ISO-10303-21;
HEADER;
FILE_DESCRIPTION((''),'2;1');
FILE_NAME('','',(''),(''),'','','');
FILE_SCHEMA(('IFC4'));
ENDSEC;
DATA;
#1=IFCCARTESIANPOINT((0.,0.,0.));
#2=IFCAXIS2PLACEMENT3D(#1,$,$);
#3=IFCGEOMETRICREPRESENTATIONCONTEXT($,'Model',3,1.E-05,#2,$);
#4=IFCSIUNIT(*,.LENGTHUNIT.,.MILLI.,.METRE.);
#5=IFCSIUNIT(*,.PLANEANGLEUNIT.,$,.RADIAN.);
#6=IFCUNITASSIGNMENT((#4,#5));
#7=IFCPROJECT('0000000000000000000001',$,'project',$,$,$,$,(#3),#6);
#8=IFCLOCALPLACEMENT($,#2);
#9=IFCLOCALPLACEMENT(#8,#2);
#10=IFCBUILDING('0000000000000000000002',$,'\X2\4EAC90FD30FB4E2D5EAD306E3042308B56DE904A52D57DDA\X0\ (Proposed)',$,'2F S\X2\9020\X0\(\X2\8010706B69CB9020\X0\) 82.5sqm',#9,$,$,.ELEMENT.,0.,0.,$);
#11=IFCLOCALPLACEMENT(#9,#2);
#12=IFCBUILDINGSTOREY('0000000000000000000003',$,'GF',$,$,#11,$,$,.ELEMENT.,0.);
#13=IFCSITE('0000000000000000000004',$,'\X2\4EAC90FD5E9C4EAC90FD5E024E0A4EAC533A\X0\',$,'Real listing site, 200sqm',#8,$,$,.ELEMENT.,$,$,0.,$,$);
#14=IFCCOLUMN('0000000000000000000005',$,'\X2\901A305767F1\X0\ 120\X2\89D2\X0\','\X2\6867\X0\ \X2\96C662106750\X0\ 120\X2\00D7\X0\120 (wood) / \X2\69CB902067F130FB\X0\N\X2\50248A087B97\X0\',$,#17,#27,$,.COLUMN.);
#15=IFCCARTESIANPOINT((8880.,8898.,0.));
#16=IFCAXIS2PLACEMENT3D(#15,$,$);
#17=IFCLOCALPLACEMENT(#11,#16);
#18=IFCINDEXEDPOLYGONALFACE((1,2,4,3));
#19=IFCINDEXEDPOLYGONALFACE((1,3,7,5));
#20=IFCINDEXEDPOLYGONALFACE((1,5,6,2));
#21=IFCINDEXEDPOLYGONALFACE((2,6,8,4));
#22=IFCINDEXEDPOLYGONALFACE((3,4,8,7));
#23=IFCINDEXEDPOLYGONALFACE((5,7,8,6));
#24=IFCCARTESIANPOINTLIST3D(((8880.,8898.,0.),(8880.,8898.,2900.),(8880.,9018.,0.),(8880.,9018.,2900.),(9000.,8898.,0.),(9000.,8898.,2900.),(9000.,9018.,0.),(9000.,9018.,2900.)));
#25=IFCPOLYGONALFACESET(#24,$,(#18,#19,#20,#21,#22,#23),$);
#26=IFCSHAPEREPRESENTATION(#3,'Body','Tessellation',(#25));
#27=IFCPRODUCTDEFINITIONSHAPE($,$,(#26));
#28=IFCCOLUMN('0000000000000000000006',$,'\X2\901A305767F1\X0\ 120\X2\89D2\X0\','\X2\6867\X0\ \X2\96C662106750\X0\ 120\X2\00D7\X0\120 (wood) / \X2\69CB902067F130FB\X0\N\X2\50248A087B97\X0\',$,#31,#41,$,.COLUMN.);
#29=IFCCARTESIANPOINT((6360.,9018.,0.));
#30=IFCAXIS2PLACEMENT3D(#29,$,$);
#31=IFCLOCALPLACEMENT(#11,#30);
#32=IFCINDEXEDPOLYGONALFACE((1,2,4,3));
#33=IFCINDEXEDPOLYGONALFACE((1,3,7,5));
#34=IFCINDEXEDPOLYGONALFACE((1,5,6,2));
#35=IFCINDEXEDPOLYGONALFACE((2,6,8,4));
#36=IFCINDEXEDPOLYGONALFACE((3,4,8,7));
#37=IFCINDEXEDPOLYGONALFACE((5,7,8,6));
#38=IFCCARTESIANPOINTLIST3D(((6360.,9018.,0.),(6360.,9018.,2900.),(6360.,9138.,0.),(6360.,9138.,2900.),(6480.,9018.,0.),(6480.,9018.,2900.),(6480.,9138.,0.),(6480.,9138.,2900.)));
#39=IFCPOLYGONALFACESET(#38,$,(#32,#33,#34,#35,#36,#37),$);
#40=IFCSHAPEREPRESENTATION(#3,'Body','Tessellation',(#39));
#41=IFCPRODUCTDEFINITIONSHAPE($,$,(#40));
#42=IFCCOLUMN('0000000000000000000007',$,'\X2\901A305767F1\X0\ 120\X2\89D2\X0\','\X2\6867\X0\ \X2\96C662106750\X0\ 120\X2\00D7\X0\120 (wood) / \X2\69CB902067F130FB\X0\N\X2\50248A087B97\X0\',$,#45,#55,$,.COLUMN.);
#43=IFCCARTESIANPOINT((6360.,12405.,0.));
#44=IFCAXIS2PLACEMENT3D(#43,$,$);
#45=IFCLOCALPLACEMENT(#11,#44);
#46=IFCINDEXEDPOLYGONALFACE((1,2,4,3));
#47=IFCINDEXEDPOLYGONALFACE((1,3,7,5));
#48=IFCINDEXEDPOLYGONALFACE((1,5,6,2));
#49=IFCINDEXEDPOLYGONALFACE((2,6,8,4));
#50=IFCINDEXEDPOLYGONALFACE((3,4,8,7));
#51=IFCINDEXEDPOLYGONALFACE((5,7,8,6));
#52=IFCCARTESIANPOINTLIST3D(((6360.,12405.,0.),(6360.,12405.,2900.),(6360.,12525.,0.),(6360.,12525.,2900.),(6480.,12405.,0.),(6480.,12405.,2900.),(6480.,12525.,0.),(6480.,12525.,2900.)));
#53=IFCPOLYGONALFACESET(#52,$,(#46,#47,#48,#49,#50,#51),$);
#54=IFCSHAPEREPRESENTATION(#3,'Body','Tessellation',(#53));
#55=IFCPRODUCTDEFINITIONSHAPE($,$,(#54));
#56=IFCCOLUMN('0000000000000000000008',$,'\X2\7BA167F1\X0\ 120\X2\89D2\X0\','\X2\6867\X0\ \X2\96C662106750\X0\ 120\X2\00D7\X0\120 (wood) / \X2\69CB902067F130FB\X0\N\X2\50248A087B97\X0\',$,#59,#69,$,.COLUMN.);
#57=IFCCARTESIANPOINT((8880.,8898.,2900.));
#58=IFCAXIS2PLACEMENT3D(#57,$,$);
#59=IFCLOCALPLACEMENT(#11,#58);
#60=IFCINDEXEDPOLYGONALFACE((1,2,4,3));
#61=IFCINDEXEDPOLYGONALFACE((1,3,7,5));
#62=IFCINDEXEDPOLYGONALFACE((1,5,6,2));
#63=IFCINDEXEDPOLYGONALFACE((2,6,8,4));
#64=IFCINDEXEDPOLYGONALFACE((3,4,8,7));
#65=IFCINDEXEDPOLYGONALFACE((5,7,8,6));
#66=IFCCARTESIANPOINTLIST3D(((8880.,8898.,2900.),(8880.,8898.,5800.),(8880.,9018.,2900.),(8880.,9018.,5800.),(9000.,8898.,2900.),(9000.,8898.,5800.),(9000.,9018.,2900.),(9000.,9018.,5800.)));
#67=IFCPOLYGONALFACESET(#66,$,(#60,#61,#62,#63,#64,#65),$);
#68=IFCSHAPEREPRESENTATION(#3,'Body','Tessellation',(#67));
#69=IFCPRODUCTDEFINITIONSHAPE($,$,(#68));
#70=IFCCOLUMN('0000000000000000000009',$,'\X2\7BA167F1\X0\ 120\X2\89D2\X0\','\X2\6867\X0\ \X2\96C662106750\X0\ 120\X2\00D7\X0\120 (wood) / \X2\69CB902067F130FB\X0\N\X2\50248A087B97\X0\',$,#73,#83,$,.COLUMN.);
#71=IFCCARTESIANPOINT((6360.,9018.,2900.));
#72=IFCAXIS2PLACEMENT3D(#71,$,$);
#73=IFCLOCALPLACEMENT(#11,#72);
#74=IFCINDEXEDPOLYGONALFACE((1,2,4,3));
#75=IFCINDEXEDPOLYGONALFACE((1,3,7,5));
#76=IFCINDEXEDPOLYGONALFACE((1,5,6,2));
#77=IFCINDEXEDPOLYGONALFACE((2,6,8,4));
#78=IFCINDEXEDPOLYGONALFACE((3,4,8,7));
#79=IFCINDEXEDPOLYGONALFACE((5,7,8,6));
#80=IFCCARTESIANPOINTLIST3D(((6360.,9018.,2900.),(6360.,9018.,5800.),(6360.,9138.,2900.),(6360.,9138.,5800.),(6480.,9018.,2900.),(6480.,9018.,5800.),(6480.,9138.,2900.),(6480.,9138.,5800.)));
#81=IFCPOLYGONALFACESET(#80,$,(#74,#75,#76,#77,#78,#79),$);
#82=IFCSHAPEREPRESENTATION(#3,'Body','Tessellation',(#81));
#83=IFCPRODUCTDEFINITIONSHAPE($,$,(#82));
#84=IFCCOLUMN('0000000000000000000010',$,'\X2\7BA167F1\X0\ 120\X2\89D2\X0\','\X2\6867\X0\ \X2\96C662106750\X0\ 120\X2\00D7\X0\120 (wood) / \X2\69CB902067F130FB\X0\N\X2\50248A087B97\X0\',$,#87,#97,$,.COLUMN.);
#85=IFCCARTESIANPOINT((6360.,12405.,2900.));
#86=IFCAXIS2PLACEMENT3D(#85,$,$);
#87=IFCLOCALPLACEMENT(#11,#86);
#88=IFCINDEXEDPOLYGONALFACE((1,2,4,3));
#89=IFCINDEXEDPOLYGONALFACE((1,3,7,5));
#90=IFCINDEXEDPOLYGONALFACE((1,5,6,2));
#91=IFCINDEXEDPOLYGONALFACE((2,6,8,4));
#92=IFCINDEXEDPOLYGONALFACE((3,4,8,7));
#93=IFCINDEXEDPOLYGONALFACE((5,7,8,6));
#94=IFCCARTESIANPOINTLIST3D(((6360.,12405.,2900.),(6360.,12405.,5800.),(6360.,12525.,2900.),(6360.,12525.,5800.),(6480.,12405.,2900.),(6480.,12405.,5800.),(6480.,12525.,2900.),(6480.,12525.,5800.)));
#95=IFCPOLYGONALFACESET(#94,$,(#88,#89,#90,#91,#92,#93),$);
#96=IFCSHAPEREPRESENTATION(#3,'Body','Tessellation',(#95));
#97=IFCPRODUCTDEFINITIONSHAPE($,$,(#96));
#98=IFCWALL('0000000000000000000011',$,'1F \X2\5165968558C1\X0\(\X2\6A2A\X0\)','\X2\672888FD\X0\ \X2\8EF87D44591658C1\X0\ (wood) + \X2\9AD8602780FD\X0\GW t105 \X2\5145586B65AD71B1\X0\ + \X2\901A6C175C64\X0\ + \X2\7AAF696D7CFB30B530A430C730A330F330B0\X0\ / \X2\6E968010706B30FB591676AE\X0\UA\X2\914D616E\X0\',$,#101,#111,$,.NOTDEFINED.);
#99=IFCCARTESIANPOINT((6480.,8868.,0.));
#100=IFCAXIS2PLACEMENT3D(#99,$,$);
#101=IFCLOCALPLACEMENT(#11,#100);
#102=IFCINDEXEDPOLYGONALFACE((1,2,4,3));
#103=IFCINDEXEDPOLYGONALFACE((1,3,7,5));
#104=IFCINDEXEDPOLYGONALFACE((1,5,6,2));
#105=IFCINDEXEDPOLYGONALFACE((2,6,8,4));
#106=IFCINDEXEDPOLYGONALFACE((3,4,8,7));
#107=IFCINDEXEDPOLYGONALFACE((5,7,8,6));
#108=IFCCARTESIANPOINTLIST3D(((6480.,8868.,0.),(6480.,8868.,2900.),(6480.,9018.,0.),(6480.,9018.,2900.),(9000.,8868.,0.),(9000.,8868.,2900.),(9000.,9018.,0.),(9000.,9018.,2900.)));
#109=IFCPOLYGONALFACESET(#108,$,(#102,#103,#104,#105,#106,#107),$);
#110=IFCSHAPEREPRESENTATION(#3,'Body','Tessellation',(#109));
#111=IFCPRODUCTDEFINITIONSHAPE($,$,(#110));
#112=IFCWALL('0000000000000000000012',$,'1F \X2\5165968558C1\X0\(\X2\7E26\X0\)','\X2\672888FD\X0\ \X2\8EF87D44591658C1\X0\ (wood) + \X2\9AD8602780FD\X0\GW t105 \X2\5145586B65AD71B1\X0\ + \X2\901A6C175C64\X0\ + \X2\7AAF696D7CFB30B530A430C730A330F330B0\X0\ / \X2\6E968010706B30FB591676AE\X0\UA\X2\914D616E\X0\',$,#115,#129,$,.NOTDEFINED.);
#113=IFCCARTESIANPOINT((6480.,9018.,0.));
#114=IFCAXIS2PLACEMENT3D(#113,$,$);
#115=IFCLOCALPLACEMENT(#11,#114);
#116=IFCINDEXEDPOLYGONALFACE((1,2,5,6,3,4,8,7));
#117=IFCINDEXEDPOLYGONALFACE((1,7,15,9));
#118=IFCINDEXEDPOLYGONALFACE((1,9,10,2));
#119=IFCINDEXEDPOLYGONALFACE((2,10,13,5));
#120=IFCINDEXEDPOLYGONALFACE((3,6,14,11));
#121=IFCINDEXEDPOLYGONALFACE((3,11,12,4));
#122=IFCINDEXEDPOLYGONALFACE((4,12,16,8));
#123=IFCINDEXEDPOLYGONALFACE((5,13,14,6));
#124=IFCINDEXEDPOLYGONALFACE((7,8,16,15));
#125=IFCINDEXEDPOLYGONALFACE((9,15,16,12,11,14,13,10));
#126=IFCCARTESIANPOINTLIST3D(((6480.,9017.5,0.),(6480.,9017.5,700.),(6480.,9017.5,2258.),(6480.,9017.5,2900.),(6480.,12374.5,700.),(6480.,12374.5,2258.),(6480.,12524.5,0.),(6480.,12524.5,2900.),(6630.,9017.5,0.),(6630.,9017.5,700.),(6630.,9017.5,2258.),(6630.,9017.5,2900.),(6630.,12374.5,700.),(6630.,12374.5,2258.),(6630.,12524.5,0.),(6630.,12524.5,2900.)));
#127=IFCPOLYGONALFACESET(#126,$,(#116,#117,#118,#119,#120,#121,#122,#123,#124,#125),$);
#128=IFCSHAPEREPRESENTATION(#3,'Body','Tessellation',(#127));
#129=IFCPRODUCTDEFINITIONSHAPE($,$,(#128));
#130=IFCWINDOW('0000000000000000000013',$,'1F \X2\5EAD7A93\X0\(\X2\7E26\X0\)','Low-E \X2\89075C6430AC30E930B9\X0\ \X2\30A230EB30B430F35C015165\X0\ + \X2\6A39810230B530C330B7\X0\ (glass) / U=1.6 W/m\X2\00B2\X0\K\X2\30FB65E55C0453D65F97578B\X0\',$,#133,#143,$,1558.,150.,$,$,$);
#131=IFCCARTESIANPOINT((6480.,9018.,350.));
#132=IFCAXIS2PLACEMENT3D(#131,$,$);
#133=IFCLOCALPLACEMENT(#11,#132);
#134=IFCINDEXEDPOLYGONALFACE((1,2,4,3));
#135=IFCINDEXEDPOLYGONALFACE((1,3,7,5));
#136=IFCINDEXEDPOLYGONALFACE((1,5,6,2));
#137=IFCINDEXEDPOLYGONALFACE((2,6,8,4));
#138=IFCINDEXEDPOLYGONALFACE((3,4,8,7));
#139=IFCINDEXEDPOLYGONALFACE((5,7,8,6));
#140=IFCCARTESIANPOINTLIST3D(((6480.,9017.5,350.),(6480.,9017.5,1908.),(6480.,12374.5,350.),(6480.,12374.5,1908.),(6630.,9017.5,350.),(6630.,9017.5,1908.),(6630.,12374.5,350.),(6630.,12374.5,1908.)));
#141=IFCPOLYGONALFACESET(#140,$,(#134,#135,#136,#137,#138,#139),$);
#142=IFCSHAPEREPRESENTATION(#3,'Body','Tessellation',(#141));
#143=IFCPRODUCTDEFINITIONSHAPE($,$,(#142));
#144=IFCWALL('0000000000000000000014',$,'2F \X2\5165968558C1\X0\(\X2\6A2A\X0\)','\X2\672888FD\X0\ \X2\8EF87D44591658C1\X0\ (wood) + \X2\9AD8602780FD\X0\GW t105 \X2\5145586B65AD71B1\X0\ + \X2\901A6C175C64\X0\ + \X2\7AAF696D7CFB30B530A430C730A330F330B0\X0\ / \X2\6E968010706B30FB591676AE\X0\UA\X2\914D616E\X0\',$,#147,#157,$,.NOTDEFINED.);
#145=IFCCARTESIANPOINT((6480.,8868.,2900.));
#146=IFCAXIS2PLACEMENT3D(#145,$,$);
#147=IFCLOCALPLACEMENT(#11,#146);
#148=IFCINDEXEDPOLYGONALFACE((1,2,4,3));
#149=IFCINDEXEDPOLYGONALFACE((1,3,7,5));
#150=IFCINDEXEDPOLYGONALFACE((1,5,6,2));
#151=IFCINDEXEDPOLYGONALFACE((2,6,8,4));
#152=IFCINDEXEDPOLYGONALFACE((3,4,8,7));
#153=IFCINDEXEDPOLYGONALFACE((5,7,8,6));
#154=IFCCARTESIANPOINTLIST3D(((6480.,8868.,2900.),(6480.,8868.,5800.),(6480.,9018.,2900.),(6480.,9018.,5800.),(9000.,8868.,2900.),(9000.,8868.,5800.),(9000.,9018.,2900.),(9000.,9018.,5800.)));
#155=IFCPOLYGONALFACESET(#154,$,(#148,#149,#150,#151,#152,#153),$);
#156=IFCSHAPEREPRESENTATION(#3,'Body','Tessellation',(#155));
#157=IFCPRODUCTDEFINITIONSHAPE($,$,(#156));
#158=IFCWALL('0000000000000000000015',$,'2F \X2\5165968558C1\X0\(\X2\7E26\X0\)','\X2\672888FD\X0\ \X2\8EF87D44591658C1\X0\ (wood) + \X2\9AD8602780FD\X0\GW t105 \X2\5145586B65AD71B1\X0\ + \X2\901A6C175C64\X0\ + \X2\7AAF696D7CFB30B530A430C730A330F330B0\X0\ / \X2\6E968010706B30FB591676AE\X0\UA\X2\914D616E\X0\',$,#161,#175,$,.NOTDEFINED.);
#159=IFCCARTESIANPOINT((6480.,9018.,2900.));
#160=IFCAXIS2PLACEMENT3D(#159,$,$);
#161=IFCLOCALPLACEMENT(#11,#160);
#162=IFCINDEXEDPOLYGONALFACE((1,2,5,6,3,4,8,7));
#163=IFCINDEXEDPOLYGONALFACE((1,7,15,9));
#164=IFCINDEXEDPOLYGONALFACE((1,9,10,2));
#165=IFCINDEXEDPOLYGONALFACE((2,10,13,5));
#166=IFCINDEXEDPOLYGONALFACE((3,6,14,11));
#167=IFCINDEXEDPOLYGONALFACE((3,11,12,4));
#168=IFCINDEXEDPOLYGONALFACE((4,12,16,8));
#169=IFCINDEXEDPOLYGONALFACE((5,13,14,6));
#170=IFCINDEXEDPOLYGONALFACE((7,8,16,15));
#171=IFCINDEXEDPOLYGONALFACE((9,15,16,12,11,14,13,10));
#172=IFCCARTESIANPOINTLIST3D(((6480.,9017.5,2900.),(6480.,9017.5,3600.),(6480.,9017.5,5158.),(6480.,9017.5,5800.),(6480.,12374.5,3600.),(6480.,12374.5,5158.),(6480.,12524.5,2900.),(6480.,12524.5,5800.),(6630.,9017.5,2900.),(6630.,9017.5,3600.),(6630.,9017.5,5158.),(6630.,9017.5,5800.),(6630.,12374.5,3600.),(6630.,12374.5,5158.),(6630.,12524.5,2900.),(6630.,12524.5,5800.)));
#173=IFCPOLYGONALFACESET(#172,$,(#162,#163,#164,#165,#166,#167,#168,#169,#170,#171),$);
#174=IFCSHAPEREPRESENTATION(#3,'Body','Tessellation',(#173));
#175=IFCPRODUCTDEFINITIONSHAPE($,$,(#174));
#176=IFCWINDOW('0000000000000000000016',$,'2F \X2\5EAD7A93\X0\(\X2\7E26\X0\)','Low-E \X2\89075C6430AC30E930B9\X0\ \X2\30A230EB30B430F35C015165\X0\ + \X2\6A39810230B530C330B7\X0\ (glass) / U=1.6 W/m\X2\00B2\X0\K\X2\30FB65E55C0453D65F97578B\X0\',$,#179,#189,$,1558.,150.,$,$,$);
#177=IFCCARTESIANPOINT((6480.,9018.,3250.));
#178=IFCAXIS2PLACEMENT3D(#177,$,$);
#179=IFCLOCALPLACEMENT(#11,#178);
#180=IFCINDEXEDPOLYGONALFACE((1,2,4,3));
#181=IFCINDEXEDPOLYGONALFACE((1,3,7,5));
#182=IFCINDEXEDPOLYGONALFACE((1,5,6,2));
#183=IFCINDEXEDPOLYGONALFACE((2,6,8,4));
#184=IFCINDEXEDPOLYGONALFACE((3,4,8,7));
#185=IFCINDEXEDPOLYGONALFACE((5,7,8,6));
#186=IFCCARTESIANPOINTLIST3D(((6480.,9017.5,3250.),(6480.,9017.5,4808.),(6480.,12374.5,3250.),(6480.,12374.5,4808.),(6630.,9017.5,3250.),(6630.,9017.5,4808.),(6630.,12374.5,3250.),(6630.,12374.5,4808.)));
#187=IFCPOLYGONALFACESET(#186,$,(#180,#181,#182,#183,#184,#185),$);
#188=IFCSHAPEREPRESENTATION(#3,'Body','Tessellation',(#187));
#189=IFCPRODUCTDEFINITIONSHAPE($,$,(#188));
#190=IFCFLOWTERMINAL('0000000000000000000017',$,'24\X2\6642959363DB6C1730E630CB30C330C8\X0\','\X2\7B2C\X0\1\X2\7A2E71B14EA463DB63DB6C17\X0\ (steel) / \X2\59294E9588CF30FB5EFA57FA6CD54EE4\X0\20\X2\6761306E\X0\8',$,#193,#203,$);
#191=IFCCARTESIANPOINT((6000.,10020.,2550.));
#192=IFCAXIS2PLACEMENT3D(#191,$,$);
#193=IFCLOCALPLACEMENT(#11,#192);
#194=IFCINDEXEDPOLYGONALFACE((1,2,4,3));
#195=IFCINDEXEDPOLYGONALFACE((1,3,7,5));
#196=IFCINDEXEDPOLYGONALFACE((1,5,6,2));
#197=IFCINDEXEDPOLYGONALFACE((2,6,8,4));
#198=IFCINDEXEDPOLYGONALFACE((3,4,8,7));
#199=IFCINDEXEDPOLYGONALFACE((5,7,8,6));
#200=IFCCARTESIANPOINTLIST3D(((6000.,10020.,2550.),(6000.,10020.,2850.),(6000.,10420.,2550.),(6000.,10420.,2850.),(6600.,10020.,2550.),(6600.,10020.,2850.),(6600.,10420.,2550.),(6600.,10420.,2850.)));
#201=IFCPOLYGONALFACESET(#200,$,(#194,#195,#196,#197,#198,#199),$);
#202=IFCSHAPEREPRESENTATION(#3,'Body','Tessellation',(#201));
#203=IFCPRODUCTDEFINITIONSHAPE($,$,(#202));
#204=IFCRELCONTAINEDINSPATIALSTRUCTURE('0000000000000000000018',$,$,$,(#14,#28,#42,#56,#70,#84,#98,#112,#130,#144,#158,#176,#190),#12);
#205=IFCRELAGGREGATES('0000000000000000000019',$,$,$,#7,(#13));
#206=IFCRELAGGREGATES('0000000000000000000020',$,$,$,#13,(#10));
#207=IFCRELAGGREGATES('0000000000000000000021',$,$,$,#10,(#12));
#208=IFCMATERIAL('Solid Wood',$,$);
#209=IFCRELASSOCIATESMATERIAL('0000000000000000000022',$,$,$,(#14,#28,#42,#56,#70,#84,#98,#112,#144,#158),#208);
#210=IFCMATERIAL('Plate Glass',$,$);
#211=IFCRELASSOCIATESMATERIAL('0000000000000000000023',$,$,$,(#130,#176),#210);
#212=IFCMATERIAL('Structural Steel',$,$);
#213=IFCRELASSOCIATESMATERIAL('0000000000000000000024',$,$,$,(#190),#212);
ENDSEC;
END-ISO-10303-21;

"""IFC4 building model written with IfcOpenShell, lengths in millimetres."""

from ifc_helpers import new_model, si_unit, frame, frame_2d, origin, place, context, project, spatial, rectangle, extrude, material, element, fill, save


model = new_model("IFC4")

# Units and contexts
model_context = context("Model", 3, precision=1e-05, world=origin())
ifc_project = project(units=[si_unit("LENGTHUNIT", "METRE", prefix="MILLI"), si_unit("PLANEANGLEUNIT", "RADIAN")], contexts=[model_context])

# Site, building, storey
site_placement = place(None, origin())
site = spatial("IfcSite", under=ifc_project, at=site_placement, Name="京都府京都市上京区", ObjectType="Real listing site, 200sqm", CompositionType="ELEMENT", RefElevation=0.0)
building_placement = place(site_placement, origin())
building = spatial("IfcBuilding", under=site, at=building_placement, Name="京都・中庭のある回遊動線 (Proposed)", ObjectType="2F S造(耐火構造) 82.5sqm", CompositionType="ELEMENT", ElevationOfRefHeight=0.0, ElevationOfTerrain=0.0)
storey_placement = place(building_placement, origin())
storey = spatial("IfcBuildingStorey", under=building, at=storey_placement, Name="GF", CompositionType="ELEMENT", Elevation=0.0)

# Columns
ifc_material_1 = material(Name="Solid Wood")
column_1_placement = place(storey_placement, frame((8880.0, 8898.0, 0.0)))
element("IfcColumn", 1, at=column_1_placement, inside=storey, material=ifc_material_1, Name="通し柱 120角", Description="桧 集成材 120×120 (wood) / 構造柱・N値計算", PredefinedType="COLUMN", context=model_context, shape_type="SweptSolid", body=[
    extrude(rectangle(XDim=120.0, YDim=120.0, at=frame_2d((60.0, 60.0))), frame((8880.0, 8898.0, 0.0)), (0.0, 0.0, 1.0), 2900.0),
])
column_2_placement = place(storey_placement, frame((6360.0, 9018.0, 0.0)))
element("IfcColumn", 2, at=column_2_placement, inside=storey, material=ifc_material_1, Name="通し柱 120角", Description="桧 集成材 120×120 (wood) / 構造柱・N値計算", PredefinedType="COLUMN", context=model_context, shape_type="SweptSolid", body=[
    extrude(rectangle(XDim=120.0, YDim=120.0, at=frame_2d((60.0, 60.0))), frame((6360.0, 9018.0, 0.0)), (0.0, 0.0, 1.0), 2900.0),
])
column_3_placement = place(storey_placement, frame((6360.0, 12405.0, 0.0)))
element("IfcColumn", 3, at=column_3_placement, inside=storey, material=ifc_material_1, Name="通し柱 120角", Description="桧 集成材 120×120 (wood) / 構造柱・N値計算", PredefinedType="COLUMN", context=model_context, shape_type="SweptSolid", body=[
    extrude(rectangle(XDim=120.0, YDim=120.0, at=frame_2d((60.0, 60.0))), frame((6360.0, 12405.0, 0.0)), (0.0, 0.0, 1.0), 2900.0),
])
column_4_placement = place(storey_placement, frame((8880.0, 8898.0, 2900.0)))
element("IfcColumn", 4, at=column_4_placement, inside=storey, material=ifc_material_1, Name="管柱 120角", Description="桧 集成材 120×120 (wood) / 構造柱・N値計算", PredefinedType="COLUMN", context=model_context, shape_type="SweptSolid", body=[
    extrude(rectangle(XDim=120.0, YDim=120.0, at=frame_2d((60.0, 60.0))), frame((8880.0, 8898.0, 2900.0)), (0.0, 0.0, 1.0), 2900.0),
])
column_5_placement = place(storey_placement, frame((6360.0, 9018.0, 2900.0)))
element("IfcColumn", 5, at=column_5_placement, inside=storey, material=ifc_material_1, Name="管柱 120角", Description="桧 集成材 120×120 (wood) / 構造柱・N値計算", PredefinedType="COLUMN", context=model_context, shape_type="SweptSolid", body=[
    extrude(rectangle(XDim=120.0, YDim=120.0, at=frame_2d((60.0, 60.0))), frame((6360.0, 9018.0, 2900.0)), (0.0, 0.0, 1.0), 2900.0),
])
column_6_placement = place(storey_placement, frame((6360.0, 12405.0, 2900.0)))
element("IfcColumn", 6, at=column_6_placement, inside=storey, material=ifc_material_1, Name="管柱 120角", Description="桧 集成材 120×120 (wood) / 構造柱・N値計算", PredefinedType="COLUMN", context=model_context, shape_type="SweptSolid", body=[
    extrude(rectangle(XDim=120.0, YDim=120.0, at=frame_2d((60.0, 60.0))), frame((6360.0, 12405.0, 2900.0)), (0.0, 0.0, 1.0), 2900.0),
])

# Wall
wall_1_placement = place(storey_placement, frame((6480.0, 8868.0, 0.0)))
element("IfcWall", 7, at=wall_1_placement, inside=storey, material=ifc_material_1, Name="1F 入隅壁(横)", Description="木製 軸組外壁 (wood) + 高性能GW t105 充填断熱 + 通気層 + 窯業系サイディング / 準耐火・外皮UA配慮", PredefinedType="NOTDEFINED", context=model_context, shape_type="SweptSolid", body=[
    extrude(rectangle(XDim=2520.0, YDim=150.0, at=frame_2d((1260.0, 75.0))), frame((6480.0, 8868.0, 0.0)), (0.0, 0.0, 1.0), 2900.0),
])

# Wall, opening, window
wall_2_placement = place(storey_placement, frame((6480.0, 9018.0, 0.0)))
wall_2 = element("IfcWall", 8, at=wall_2_placement, inside=storey, material=ifc_material_1, Name="1F 入隅壁(縦)", Description="木製 軸組外壁 (wood) + 高性能GW t105 充填断熱 + 通気層 + 窯業系サイディング / 準耐火・外皮UA配慮", PredefinedType="NOTDEFINED", context=model_context, shape_type="SweptSolid", body=[
    extrude(rectangle(XDim=150.0, YDim=3507.0, at=frame_2d((75.0, 1753.0))), frame((6480.0, 9018.0, 0.0)), (0.0, 0.0, 1.0), 2900.0),
])
opening_1_placement = place(storey_placement, frame((6480.0, 9018.0, 350.0)))
opening_1 = element("IfcOpeningElement", 9, at=opening_1_placement, cuts=wall_2, PredefinedType="NOTDEFINED", context=model_context, shape_type="SweptSolid", body=[
    extrude(rectangle(XDim=150.0, YDim=3357.0, at=frame_2d((75.0, 1678.0))), frame((6480.0, 9018.0, 350.0)), (0.0, 0.0, 1.0), 1558.0),
])
ifc_material_2 = material(Name="Plate Glass")
window_1_placement = place(storey_placement, frame((6480.0, 9018.0, 350.0)))
window_1 = element("IfcWindow", 10, at=window_1_placement, inside=storey, material=ifc_material_2, Name="1F 庭窓(縦)", Description="Low-E 複層ガラス アルゴン封入 + 樹脂サッシ (glass) / U=1.6 W/m²K・日射取得型", OverallHeight=1558.0, OverallWidth=150.0, context=model_context, shape_type="SweptSolid", body=[
    extrude(rectangle(XDim=150.0, YDim=3357.0, at=frame_2d((75.0, 1678.0))), frame((6480.0, 9018.0, 350.0)), (0.0, 0.0, 1.0), 1558.0),
])
fill(opening_1, window_1)

# Wall
wall_3_placement = place(storey_placement, frame((6480.0, 8868.0, 2900.0)))
element("IfcWall", 11, at=wall_3_placement, inside=storey, material=ifc_material_1, Name="2F 入隅壁(横)", Description="木製 軸組外壁 (wood) + 高性能GW t105 充填断熱 + 通気層 + 窯業系サイディング / 準耐火・外皮UA配慮", PredefinedType="NOTDEFINED", context=model_context, shape_type="SweptSolid", body=[
    extrude(rectangle(XDim=2520.0, YDim=150.0, at=frame_2d((1260.0, 75.0))), frame((6480.0, 8868.0, 2900.0)), (0.0, 0.0, 1.0), 2900.0),
])

# Wall, opening, window
wall_4_placement = place(storey_placement, frame((6480.0, 9018.0, 2900.0)))
wall_4 = element("IfcWall", 12, at=wall_4_placement, inside=storey, material=ifc_material_1, Name="2F 入隅壁(縦)", Description="木製 軸組外壁 (wood) + 高性能GW t105 充填断熱 + 通気層 + 窯業系サイディング / 準耐火・外皮UA配慮", PredefinedType="NOTDEFINED", context=model_context, shape_type="SweptSolid", body=[
    extrude(rectangle(XDim=150.0, YDim=3507.0, at=frame_2d((75.0, 1753.0))), frame((6480.0, 9018.0, 2900.0)), (0.0, 0.0, 1.0), 2900.0),
])
opening_2_placement = place(storey_placement, frame((6480.0, 9018.0, 3250.0)))
opening_2 = element("IfcOpeningElement", 13, at=opening_2_placement, cuts=wall_4, PredefinedType="NOTDEFINED", context=model_context, shape_type="SweptSolid", body=[
    extrude(rectangle(XDim=150.0, YDim=3357.0, at=frame_2d((75.0, 1678.0))), frame((6480.0, 9018.0, 3250.0)), (0.0, 0.0, 1.0), 1558.0),
])
window_2_placement = place(storey_placement, frame((6480.0, 9018.0, 3250.0)))
window_2 = element("IfcWindow", 14, at=window_2_placement, inside=storey, material=ifc_material_2, Name="2F 庭窓(縦)", Description="Low-E 複層ガラス アルゴン封入 + 樹脂サッシ (glass) / U=1.6 W/m²K・日射取得型", OverallHeight=1558.0, OverallWidth=150.0, context=model_context, shape_type="SweptSolid", body=[
    extrude(rectangle(XDim=150.0, YDim=3357.0, at=frame_2d((75.0, 1678.0))), frame((6480.0, 9018.0, 3250.0)), (0.0, 0.0, 1.0), 1558.0),
])
fill(opening_2, window_2)

# Flow terminal
ifc_material_3 = material(Name="Structural Steel")
flow_terminal_placement = place(storey_placement, frame((6000.0, 10020.0, 2550.0)))
element("IfcFlowTerminal", 15, at=flow_terminal_placement, inside=storey, material=ifc_material_3, Name="24時間換気ユニット", Description="第1種熱交換換気 (steel) / 天井裏・建基法令20条の8", context=model_context, shape_type="SweptSolid", body=[
    extrude(rectangle(XDim=600.0, YDim=400.0, at=frame_2d((300.0, 200.0))), frame((6000.0, 10020.0, 2550.0)), (0.0, 0.0, 1.0), 300.0),
])

save(model, "model.ifc")
